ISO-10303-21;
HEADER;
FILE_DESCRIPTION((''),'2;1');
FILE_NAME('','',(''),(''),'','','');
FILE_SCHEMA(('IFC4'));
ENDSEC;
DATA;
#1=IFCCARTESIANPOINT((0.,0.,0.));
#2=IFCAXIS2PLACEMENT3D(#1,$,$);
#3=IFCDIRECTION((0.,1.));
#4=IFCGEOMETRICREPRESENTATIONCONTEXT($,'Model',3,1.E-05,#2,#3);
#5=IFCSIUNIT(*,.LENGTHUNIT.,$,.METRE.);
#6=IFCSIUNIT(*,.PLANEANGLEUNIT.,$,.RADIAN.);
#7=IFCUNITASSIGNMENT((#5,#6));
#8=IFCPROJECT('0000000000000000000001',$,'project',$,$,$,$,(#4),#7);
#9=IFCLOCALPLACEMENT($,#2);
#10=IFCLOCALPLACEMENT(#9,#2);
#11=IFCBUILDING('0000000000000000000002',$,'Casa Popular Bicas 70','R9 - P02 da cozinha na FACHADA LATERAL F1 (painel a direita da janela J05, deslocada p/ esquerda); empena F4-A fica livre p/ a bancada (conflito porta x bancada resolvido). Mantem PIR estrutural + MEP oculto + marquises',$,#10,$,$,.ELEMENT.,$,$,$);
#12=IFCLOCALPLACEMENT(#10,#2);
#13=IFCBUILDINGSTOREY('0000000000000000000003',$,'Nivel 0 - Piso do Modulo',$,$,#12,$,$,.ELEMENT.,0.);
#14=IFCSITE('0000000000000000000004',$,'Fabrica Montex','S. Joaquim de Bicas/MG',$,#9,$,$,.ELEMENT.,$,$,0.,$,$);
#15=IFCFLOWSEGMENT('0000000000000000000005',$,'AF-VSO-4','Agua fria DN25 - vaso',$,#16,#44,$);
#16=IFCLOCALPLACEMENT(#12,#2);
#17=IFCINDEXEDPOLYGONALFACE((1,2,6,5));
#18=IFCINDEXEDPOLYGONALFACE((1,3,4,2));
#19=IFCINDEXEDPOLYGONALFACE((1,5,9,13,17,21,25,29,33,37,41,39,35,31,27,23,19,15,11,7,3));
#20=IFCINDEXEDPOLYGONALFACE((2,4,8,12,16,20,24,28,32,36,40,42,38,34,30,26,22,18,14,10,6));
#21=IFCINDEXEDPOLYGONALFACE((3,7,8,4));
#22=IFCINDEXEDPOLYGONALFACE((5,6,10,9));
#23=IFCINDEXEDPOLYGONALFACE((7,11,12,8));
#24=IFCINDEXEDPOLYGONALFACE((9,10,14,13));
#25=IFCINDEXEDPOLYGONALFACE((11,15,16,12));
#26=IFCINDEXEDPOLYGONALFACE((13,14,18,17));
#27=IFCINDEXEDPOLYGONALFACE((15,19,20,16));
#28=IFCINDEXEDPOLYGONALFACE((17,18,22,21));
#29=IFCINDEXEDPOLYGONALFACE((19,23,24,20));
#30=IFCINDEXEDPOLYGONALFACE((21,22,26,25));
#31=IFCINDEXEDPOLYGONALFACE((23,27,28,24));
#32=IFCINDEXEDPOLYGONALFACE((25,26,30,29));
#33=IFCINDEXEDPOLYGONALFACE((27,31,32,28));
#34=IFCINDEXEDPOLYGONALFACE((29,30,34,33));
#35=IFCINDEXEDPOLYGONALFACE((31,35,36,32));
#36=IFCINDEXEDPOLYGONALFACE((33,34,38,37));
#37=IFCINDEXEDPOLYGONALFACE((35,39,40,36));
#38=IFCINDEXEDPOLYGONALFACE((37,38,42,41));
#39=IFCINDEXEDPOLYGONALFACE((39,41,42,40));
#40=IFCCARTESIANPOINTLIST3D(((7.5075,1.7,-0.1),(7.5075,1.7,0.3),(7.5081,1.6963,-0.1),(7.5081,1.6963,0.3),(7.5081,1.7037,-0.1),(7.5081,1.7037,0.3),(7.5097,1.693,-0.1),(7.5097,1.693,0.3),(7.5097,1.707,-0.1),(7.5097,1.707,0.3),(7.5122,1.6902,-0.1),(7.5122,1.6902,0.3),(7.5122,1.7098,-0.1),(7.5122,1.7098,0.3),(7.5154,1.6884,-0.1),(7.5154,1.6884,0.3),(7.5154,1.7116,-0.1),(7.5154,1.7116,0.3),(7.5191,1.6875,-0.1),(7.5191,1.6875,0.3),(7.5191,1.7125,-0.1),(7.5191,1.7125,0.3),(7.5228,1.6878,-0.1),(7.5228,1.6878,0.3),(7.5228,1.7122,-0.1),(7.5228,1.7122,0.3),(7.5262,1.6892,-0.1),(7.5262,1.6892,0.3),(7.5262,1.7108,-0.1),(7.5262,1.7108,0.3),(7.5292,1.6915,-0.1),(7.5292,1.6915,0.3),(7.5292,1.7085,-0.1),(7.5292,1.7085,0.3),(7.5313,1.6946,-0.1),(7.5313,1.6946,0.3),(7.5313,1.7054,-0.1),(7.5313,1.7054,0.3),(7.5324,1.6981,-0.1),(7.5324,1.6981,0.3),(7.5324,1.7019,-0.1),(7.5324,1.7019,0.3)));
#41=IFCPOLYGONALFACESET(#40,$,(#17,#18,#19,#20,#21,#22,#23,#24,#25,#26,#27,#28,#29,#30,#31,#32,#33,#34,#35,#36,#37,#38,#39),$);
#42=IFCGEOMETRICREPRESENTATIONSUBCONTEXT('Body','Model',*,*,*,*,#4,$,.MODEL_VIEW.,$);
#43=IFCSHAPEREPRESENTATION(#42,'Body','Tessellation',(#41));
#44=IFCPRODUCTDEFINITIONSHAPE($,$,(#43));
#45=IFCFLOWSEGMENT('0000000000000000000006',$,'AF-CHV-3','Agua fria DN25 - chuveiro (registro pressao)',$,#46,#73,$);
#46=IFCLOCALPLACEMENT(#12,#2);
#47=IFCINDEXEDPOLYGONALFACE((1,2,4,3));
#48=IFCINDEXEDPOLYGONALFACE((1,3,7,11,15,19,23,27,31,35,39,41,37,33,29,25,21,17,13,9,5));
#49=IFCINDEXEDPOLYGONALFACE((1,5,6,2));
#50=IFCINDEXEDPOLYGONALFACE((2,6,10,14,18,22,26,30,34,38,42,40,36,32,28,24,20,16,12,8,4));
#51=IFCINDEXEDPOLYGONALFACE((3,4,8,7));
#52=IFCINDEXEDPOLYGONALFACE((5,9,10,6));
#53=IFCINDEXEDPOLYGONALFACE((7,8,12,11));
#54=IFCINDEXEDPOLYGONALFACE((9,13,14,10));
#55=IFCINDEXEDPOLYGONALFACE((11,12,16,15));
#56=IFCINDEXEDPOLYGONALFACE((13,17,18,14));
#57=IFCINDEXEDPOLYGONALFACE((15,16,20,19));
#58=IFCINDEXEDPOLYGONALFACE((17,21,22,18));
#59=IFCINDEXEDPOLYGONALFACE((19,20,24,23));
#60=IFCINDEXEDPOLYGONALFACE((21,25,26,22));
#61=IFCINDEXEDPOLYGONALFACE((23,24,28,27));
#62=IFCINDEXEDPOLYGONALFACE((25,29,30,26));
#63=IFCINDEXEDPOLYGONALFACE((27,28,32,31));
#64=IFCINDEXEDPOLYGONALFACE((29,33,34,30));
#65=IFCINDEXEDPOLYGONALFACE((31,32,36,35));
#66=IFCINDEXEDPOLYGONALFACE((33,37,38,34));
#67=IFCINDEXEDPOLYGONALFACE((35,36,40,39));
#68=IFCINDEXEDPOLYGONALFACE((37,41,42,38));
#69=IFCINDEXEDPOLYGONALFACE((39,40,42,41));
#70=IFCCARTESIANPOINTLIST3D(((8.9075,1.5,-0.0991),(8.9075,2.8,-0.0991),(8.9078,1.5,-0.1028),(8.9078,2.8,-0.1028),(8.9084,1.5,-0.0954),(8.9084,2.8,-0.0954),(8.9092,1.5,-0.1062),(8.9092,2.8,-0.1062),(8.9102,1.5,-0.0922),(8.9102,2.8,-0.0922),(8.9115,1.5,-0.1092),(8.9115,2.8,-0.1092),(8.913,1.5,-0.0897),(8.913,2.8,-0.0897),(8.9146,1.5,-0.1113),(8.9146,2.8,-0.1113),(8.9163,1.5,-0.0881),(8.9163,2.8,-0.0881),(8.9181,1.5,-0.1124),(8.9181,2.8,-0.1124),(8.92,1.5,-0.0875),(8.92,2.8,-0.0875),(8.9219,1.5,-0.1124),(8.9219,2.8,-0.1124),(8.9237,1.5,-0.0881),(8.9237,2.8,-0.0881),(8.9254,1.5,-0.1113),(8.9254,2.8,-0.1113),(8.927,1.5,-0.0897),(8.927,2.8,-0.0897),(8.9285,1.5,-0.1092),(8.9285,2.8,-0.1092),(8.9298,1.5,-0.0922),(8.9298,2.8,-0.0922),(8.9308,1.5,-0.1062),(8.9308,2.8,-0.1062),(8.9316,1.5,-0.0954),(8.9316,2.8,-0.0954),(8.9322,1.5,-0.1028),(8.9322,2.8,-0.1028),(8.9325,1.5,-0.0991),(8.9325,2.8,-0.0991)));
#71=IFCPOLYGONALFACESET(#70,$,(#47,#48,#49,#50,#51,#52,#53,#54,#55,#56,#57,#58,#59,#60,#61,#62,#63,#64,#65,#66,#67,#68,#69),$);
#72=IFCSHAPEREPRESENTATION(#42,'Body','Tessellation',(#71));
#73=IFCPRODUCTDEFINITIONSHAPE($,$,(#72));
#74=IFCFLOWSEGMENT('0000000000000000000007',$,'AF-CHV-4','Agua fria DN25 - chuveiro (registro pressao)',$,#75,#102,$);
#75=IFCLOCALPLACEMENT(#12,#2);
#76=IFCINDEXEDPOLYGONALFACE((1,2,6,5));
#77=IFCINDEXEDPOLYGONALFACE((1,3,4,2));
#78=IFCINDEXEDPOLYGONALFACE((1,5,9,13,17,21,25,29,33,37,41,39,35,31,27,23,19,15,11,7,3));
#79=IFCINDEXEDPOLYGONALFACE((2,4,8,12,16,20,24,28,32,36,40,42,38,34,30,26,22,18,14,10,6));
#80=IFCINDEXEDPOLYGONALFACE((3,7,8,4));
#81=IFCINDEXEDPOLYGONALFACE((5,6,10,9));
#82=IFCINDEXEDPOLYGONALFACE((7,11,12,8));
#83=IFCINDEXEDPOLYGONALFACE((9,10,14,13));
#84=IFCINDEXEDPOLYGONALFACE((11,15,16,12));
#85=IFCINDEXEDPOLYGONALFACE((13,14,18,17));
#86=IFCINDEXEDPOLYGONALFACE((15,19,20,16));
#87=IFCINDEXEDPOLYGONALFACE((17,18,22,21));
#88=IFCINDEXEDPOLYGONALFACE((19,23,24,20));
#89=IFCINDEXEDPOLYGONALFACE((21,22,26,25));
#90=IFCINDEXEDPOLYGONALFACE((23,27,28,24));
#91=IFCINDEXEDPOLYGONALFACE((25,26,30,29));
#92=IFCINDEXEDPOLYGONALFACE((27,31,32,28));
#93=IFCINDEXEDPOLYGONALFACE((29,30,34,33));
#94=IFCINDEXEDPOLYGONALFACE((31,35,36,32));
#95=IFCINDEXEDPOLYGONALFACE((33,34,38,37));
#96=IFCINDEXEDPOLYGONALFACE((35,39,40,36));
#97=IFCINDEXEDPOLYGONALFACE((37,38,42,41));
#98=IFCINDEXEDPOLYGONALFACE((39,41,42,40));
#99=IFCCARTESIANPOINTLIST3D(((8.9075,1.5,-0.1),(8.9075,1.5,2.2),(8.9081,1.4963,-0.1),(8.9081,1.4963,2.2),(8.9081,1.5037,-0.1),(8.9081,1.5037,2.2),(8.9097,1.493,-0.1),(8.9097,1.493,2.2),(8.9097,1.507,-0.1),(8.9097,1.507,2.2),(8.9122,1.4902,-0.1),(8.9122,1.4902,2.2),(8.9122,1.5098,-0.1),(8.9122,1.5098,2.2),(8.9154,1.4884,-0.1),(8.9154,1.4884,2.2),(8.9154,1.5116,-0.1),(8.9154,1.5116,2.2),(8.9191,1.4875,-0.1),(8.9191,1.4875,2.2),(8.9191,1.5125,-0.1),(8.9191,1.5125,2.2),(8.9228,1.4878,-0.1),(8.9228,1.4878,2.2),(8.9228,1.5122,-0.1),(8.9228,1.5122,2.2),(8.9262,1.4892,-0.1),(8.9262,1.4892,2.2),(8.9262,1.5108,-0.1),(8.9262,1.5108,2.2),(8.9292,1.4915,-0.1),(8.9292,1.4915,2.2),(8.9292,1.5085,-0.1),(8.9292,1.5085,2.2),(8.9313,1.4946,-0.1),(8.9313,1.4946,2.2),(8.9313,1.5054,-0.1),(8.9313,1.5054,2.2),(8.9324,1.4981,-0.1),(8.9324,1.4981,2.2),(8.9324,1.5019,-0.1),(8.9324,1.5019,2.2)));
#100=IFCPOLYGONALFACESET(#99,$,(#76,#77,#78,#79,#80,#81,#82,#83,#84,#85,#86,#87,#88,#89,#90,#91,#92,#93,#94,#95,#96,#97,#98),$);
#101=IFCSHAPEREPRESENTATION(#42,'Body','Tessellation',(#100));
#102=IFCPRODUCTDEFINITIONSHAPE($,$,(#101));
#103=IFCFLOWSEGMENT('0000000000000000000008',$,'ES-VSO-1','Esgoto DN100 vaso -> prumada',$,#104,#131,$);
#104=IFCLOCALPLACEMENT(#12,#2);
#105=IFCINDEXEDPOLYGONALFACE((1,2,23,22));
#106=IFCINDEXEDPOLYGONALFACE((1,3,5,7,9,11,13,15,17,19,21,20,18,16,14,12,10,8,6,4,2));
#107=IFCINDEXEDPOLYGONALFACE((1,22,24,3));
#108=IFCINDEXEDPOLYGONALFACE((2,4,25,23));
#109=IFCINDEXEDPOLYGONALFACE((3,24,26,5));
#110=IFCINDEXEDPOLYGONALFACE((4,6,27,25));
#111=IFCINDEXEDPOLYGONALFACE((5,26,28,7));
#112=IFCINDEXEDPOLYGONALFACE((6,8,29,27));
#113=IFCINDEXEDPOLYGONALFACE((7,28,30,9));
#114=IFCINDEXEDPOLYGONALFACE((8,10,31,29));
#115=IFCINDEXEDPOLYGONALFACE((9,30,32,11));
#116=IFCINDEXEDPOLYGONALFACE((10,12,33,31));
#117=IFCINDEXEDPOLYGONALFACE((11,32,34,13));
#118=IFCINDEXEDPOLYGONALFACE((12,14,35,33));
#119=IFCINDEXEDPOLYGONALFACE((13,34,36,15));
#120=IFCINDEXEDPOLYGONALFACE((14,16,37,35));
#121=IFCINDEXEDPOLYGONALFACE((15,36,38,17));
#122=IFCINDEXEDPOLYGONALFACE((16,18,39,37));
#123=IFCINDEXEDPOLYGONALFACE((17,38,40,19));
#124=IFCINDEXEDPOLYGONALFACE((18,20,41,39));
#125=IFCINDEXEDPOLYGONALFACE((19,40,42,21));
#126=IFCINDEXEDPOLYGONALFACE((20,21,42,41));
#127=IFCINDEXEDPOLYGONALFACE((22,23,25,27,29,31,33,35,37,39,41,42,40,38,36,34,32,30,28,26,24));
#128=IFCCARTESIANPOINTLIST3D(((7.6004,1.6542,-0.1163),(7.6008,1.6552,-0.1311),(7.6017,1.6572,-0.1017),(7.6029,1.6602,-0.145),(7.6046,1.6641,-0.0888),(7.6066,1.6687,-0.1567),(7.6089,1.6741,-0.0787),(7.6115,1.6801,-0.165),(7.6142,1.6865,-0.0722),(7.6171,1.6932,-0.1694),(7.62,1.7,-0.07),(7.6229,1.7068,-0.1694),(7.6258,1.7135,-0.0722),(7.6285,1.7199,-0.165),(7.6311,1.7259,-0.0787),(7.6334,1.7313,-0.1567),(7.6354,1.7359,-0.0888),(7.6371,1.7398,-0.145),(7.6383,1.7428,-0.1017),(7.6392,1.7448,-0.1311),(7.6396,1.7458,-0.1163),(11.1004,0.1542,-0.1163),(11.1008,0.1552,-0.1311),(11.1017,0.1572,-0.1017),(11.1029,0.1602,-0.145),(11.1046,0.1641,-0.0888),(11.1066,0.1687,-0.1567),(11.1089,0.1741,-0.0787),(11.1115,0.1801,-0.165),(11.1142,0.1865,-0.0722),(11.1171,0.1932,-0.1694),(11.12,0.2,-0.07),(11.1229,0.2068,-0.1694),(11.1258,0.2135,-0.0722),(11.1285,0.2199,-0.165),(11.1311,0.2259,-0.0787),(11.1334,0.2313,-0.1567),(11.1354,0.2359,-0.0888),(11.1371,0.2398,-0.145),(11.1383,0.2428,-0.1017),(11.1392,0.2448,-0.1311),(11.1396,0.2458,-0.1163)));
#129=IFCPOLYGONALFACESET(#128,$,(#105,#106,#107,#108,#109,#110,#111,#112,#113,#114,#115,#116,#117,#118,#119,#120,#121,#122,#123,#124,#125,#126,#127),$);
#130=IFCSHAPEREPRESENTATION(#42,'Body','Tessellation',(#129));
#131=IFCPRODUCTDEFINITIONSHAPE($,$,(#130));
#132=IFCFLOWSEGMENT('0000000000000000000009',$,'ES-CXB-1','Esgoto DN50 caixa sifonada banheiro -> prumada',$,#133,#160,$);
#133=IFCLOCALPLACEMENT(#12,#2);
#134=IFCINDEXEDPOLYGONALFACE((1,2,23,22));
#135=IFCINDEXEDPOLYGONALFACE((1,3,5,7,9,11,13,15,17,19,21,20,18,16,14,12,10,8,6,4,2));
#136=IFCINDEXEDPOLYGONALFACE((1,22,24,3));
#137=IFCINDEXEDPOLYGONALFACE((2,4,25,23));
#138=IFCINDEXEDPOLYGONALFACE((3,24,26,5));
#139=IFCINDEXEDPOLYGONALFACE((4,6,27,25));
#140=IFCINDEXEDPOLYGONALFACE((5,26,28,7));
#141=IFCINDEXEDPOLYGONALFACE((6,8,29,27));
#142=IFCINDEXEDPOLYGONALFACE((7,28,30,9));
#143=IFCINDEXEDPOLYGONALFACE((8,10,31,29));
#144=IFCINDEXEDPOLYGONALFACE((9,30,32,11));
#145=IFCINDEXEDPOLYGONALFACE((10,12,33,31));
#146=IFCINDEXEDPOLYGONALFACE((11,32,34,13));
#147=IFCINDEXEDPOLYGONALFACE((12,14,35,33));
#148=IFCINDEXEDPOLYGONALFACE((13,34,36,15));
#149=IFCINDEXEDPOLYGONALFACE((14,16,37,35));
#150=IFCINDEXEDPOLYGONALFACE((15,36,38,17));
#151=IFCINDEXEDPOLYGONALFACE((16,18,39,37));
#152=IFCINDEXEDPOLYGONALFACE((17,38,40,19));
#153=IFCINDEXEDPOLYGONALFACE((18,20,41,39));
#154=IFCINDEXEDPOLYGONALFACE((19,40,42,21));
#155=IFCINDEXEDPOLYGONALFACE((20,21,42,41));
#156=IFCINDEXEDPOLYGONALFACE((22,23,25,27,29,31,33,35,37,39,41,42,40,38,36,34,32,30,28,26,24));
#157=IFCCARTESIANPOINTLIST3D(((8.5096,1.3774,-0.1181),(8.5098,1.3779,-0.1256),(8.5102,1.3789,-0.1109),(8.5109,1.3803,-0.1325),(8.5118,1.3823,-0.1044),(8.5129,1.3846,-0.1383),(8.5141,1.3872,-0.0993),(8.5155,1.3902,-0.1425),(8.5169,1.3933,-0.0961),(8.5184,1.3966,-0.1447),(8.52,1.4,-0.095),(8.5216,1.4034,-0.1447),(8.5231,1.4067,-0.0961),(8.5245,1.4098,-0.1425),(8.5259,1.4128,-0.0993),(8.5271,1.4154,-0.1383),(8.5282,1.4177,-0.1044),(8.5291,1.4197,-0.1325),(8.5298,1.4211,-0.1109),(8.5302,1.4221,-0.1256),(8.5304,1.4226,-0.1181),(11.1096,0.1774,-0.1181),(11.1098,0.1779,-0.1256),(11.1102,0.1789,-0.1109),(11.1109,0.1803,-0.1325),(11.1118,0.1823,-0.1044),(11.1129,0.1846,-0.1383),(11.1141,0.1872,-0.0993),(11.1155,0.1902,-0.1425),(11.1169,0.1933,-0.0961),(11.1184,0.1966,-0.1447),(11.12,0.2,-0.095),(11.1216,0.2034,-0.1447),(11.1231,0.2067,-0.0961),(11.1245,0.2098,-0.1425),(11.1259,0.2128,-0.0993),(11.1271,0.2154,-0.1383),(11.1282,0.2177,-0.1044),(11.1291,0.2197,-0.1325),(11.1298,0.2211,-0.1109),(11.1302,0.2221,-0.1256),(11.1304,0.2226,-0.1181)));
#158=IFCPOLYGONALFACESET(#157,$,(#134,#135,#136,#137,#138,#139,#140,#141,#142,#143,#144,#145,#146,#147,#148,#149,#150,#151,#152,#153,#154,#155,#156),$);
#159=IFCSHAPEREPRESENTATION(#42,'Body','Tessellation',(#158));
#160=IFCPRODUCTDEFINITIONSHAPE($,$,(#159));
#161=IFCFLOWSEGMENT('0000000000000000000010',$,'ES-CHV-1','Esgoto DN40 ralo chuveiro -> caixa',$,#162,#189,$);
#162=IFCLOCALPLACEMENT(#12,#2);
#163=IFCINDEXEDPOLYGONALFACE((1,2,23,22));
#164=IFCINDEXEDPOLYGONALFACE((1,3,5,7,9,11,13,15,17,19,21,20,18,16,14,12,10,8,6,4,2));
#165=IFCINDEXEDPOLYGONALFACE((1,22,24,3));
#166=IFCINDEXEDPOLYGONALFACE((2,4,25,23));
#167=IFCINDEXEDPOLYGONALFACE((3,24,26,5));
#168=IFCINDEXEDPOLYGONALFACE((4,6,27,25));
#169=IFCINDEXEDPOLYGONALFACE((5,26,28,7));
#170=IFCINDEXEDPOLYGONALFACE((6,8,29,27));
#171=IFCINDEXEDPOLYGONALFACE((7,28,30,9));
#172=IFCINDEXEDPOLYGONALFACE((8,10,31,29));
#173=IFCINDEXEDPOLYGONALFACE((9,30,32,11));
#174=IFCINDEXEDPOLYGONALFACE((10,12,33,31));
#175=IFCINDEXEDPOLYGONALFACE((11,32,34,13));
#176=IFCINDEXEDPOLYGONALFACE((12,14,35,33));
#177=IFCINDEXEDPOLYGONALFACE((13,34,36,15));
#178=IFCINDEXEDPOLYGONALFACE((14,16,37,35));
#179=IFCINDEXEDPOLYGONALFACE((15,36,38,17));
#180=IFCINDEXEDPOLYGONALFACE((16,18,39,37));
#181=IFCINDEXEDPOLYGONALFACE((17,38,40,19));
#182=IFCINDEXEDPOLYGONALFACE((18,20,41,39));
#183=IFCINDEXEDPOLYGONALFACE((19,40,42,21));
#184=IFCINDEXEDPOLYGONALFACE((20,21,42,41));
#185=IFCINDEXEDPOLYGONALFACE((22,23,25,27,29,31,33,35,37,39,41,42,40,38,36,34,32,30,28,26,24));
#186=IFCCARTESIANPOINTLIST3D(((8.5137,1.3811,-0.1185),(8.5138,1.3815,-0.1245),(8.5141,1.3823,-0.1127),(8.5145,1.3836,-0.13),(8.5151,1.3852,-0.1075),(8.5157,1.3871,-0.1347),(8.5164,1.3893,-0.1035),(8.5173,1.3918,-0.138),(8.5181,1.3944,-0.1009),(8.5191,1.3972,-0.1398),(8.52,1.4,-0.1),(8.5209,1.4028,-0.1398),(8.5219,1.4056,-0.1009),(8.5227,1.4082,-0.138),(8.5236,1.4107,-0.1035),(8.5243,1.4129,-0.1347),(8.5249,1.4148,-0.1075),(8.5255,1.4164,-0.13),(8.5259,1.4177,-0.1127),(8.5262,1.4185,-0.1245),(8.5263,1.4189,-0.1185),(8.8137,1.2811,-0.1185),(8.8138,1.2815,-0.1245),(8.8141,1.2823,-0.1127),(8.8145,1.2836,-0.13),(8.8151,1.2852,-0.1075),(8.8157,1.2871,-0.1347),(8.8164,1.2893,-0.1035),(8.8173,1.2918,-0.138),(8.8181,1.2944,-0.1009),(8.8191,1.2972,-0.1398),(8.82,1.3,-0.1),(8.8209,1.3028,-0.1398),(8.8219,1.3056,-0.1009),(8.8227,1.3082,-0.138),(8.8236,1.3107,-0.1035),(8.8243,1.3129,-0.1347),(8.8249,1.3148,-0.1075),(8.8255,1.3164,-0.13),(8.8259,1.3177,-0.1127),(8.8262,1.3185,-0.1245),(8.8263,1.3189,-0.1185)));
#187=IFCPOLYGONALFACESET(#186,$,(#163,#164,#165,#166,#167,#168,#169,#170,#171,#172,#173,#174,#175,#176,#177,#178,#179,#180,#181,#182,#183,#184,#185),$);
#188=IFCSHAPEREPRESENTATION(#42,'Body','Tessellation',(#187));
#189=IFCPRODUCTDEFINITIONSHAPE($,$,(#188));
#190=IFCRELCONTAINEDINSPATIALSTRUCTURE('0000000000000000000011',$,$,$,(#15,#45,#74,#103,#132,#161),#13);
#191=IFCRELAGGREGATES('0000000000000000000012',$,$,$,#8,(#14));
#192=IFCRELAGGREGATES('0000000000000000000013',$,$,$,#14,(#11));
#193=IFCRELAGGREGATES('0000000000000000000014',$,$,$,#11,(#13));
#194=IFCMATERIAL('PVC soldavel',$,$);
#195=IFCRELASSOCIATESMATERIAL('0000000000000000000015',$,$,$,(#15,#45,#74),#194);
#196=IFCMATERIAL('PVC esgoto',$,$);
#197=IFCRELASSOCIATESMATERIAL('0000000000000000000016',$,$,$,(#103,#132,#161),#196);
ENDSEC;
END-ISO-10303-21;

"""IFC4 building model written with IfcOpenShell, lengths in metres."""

from ifc_helpers import new_model, si_unit, direction, frame, origin, origin_2d, place, context, subcontext, project, spatial, circle, extrude, material, element, save


model = new_model("IFC4")

# Units and contexts
model_context = context("Model", 3, precision=1e-05, world=origin(), true_north=direction((0.0, 1.0)))
body_context = subcontext(model_context, "Body", "Model", "MODEL_VIEW")
ifc_project = project(units=[si_unit("LENGTHUNIT", "METRE"), si_unit("PLANEANGLEUNIT", "RADIAN")], contexts=[model_context])

# Site, building, storey
site_placement = place(None, origin())
site = spatial("IfcSite", under=ifc_project, at=site_placement, Name="Fabrica Montex", Description="S. Joaquim de Bicas/MG", CompositionType="ELEMENT", RefElevation=0.0)
building_placement = place(site_placement, origin())
building = spatial("IfcBuilding", under=site, at=building_placement, Name="Casa Popular Bicas 70", Description="R9 - P02 da cozinha na FACHADA LATERAL F1 (painel a direita da janela J05, deslocada p/ esquerda); empena F4-A fica livre p/ a bancada (conflito porta x bancada resolvido). Mantem PIR estrutural + MEP oculto + marquises", CompositionType="ELEMENT")
storey_placement = place(building_placement, origin())
storey = spatial("IfcBuildingStorey", under=building, at=storey_placement, Name="Nivel 0 - Piso do Modulo", CompositionType="ELEMENT", Elevation=0.0)

# Flow segments
ifc_material_1 = material(Name="PVC soldavel")
flow_segment_1_placement = place(None, frame((7.52, 1.7, -0.1), z_axis=(0.0, 0.0, 1.0), x_axis=(-1.0, 0.0, 0.0)))
element("IfcFlowSegment", 1, at=flow_segment_1_placement, inside=storey, material=ifc_material_1, Name="AF-VSO-4", Description="Agua fria DN25 - vaso", context=body_context, shape_type="SweptSolid", body=[
    extrude(circle(Radius=0.0125, at=origin_2d()), origin(), (0.0, 0.0, 1.0), 0.4),
])
flow_segment_2_placement = place(None, frame((8.92, 2.8, -0.1), z_axis=(0.0, -1.0, 0.0), x_axis=(0.0, 0.0, 1.0)))
element("IfcFlowSegment", 2, at=flow_segment_2_placement, inside=storey, material=ifc_material_1, Name="AF-CHV-3", Description="Agua fria DN25 - chuveiro (registro pressao)", context=body_context, shape_type="SweptSolid", body=[
    extrude(circle(Radius=0.0125, at=origin_2d()), origin(), (0.0, 0.0, 1.0), 1.3),
])
flow_segment_3_placement = place(None, frame((8.92, 1.5, -0.1), z_axis=(0.0, 0.0, 1.0), x_axis=(-1.0, 0.0, 0.0)))
element("IfcFlowSegment", 3, at=flow_segment_3_placement, inside=storey, material=ifc_material_1, Name="AF-CHV-4", Description="Agua fria DN25 - chuveiro (registro pressao)", context=body_context, shape_type="SweptSolid", body=[
    extrude(circle(Radius=0.0125, at=origin_2d()), origin(), (0.0, 0.0, 1.0), 2.3),
])
ifc_material_2 = material(Name="PVC esgoto")
flow_segment_4_placement = place(None, frame((7.62, 1.7, -0.12), z_axis=(0.919145, -0.393919, 0.0), x_axis=(0.0, 0.0, 1.0)))
element("IfcFlowSegment", 4, at=flow_segment_4_placement, inside=storey, material=ifc_material_2, Name="ES-VSO-1", Description="Esgoto DN100 vaso -> prumada", context=body_context, shape_type="SweptSolid", body=[
    extrude(circle(Radius=0.05, at=origin_2d()), origin(), (0.0, 0.0, 1.0), 3.8079),
])
flow_segment_5_placement = place(None, frame((8.52, 1.4, -0.12), z_axis=(0.907959, -0.419058, 0.0), x_axis=(0.0, 0.0, 1.0)))
element("IfcFlowSegment", 5, at=flow_segment_5_placement, inside=storey, material=ifc_material_2, Name="ES-CXB-1", Description="Esgoto DN50 caixa sifonada banheiro -> prumada", context=body_context, shape_type="SweptSolid", body=[
    extrude(circle(Radius=0.025, at=origin_2d()), origin(), (0.0, 0.0, 1.0), 2.8636),
])
flow_segment_6_placement = place(None, frame((8.82, 1.3, -0.12), z_axis=(-0.948683, 0.316228, 0.0), x_axis=(0.0, 0.0, 1.0)))
element("IfcFlowSegment", 6, at=flow_segment_6_placement, inside=storey, material=ifc_material_2, Name="ES-CHV-1", Description="Esgoto DN40 ralo chuveiro -> caixa", context=body_context, shape_type="SweptSolid", body=[
    extrude(circle(Radius=0.02, at=origin_2d()), origin(), (0.0, 0.0, 1.0), 0.3162),
])

save(model, "model.ifc")
